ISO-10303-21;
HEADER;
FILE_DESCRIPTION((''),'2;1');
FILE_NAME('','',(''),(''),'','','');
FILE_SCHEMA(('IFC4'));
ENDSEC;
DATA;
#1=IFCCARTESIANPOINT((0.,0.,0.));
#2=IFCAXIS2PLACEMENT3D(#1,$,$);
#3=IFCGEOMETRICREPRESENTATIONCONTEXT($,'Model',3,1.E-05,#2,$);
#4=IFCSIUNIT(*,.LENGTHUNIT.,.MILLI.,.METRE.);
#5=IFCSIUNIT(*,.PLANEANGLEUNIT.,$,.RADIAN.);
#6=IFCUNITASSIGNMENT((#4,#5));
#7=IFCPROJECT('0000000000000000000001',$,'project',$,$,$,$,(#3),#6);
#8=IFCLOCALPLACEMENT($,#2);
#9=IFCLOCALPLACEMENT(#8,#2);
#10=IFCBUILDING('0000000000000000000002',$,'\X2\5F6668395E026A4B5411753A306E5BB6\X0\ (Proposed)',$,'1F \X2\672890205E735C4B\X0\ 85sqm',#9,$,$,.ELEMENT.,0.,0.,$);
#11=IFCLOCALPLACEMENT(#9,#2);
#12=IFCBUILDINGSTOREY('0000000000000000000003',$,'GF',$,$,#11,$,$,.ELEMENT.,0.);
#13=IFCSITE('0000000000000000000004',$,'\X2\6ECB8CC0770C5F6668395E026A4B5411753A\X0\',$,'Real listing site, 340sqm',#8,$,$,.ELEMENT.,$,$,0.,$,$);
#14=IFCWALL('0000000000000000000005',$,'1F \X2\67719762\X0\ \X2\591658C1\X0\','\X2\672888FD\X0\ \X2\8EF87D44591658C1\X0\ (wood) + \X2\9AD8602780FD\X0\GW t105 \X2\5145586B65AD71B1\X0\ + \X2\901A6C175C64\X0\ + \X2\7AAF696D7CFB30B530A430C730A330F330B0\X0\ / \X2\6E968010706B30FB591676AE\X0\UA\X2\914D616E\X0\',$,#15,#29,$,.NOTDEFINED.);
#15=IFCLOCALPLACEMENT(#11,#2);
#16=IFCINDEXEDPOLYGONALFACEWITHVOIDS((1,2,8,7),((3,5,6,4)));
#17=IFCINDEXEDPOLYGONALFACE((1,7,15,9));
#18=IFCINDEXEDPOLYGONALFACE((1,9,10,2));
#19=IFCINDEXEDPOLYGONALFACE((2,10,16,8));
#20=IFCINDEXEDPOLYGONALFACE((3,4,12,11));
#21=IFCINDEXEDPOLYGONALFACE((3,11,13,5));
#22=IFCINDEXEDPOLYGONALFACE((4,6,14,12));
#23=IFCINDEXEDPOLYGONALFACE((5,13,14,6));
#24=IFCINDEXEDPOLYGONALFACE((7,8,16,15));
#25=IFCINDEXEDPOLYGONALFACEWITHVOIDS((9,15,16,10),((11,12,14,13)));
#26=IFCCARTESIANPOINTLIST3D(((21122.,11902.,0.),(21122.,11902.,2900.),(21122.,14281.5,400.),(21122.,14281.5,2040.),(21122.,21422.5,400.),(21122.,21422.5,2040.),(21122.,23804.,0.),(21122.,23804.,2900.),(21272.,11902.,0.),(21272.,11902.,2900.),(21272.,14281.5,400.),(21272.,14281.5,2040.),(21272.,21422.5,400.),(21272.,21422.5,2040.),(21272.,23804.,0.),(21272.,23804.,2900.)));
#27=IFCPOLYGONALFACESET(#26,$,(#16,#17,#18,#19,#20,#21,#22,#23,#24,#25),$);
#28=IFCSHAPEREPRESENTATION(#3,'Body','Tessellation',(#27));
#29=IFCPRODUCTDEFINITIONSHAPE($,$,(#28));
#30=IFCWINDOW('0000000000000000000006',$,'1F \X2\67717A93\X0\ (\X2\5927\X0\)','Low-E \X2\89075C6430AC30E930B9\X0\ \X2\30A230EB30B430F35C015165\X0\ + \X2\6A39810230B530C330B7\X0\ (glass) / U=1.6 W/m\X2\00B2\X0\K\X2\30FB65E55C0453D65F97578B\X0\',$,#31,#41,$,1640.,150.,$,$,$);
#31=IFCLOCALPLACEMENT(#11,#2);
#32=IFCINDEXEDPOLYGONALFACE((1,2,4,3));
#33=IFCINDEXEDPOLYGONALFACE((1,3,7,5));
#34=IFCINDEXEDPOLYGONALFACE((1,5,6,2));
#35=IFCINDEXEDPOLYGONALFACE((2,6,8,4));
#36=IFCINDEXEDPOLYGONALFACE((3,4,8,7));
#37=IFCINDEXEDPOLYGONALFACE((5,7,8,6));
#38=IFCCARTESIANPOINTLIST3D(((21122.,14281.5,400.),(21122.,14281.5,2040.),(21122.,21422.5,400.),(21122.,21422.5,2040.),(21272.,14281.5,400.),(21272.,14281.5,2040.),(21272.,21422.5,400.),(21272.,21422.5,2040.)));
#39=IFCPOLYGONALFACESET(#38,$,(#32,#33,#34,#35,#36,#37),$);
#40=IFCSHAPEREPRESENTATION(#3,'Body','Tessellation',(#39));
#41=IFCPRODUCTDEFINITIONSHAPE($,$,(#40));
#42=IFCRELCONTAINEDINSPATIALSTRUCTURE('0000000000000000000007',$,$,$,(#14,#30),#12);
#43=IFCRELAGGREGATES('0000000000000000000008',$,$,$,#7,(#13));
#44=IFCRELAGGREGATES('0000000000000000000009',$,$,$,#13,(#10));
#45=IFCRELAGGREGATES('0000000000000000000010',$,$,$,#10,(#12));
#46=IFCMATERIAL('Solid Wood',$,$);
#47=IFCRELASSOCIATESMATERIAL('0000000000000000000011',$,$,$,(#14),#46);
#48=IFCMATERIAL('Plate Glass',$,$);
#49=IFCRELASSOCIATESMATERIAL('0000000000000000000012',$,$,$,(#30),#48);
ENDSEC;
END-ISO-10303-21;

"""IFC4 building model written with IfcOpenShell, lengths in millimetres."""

from ifc_helpers import new_model, si_unit, frame, frame_2d, origin, place, context, project, spatial, rectangle, extrude, material, element, fill, save


model = new_model("IFC4")

# Units and contexts
model_context = context("Model", 3, precision=1e-05, world=origin())
ifc_project = project(units=[si_unit("LENGTHUNIT", "METRE", prefix="MILLI"), si_unit("PLANEANGLEUNIT", "RADIAN")], contexts=[model_context])

# Site, building, storey
site_placement = place(None, origin())
site = spatial("IfcSite", under=ifc_project, at=site_placement, Name="滋賀県彦根市橋向町", ObjectType="Real listing site, 340sqm", CompositionType="ELEMENT", RefElevation=0.0)
building_placement = place(site_placement, origin())
building = spatial("IfcBuilding", under=site, at=building_placement, Name="彦根市橋向町の家 (Proposed)", ObjectType="1F 木造平屋 85sqm", CompositionType="ELEMENT", ElevationOfRefHeight=0.0, ElevationOfTerrain=0.0)
storey_placement = place(building_placement, origin())
storey = spatial("IfcBuildingStorey", under=building, at=storey_placement, Name="GF", CompositionType="ELEMENT", Elevation=0.0)

# Shared definitions
ifc_material_1 = material(Name="Solid Wood")

# Shared definitions
ifc_material_2 = material(Name="Plate Glass")

# Wall, opening, window
wall_1_placement = place(storey_placement, frame((10561.0, 5951.0, 0.0)))
wall_1 = element("IfcWall", 1, at=wall_1_placement, inside=storey, material=ifc_material_1, Name="1F 東面 外壁", Description="木製 軸組外壁 (wood) + 高性能GW t105 充填断熱 + 通気層 + 窯業系サイディング / 準耐火・外皮UA配慮", PredefinedType="NOTDEFINED", context=model_context, shape_type="SweptSolid", body=[
    extrude(rectangle(XDim=150.0, YDim=11902.0, at=frame_2d((75.0, 5951.0))), frame((10561.0, 5951.0, 0.0)), (0.0, 0.0, 1.0), 2900.0),
])
opening_1_placement = place(storey_placement, frame((10561.0, 7141.0, 200.0)))
opening_1 = element("IfcOpeningElement", 2, at=opening_1_placement, cuts=wall_1, PredefinedType="NOTDEFINED", context=model_context, shape_type="SweptSolid", body=[
    extrude(rectangle(XDim=150.0, YDim=7141.0, at=frame_2d((75.0, 3570.0))), frame((10561.0, 7141.0, 200.0)), (0.0, 0.0, 1.0), 1640.0),
])
window_1_placement = place(storey_placement, frame((10561.0, 7141.0, 200.0)))
window_1 = element("IfcWindow", 3, at=window_1_placement, inside=storey, material=ifc_material_2, Name="1F 東窓 (大)", Description="Low-E 複層ガラス アルゴン封入 + 樹脂サッシ (glass) / U=1.6 W/m²K・日射取得型", OverallHeight=1640.0, OverallWidth=150.0, context=model_context, shape_type="SweptSolid", body=[
    extrude(rectangle(XDim=150.0, YDim=7141.0, at=frame_2d((75.0, 3570.0))), frame((10561.0, 7141.0, 200.0)), (0.0, 0.0, 1.0), 1640.0),
])
fill(opening_1, window_1)

save(model, "model.ifc")
